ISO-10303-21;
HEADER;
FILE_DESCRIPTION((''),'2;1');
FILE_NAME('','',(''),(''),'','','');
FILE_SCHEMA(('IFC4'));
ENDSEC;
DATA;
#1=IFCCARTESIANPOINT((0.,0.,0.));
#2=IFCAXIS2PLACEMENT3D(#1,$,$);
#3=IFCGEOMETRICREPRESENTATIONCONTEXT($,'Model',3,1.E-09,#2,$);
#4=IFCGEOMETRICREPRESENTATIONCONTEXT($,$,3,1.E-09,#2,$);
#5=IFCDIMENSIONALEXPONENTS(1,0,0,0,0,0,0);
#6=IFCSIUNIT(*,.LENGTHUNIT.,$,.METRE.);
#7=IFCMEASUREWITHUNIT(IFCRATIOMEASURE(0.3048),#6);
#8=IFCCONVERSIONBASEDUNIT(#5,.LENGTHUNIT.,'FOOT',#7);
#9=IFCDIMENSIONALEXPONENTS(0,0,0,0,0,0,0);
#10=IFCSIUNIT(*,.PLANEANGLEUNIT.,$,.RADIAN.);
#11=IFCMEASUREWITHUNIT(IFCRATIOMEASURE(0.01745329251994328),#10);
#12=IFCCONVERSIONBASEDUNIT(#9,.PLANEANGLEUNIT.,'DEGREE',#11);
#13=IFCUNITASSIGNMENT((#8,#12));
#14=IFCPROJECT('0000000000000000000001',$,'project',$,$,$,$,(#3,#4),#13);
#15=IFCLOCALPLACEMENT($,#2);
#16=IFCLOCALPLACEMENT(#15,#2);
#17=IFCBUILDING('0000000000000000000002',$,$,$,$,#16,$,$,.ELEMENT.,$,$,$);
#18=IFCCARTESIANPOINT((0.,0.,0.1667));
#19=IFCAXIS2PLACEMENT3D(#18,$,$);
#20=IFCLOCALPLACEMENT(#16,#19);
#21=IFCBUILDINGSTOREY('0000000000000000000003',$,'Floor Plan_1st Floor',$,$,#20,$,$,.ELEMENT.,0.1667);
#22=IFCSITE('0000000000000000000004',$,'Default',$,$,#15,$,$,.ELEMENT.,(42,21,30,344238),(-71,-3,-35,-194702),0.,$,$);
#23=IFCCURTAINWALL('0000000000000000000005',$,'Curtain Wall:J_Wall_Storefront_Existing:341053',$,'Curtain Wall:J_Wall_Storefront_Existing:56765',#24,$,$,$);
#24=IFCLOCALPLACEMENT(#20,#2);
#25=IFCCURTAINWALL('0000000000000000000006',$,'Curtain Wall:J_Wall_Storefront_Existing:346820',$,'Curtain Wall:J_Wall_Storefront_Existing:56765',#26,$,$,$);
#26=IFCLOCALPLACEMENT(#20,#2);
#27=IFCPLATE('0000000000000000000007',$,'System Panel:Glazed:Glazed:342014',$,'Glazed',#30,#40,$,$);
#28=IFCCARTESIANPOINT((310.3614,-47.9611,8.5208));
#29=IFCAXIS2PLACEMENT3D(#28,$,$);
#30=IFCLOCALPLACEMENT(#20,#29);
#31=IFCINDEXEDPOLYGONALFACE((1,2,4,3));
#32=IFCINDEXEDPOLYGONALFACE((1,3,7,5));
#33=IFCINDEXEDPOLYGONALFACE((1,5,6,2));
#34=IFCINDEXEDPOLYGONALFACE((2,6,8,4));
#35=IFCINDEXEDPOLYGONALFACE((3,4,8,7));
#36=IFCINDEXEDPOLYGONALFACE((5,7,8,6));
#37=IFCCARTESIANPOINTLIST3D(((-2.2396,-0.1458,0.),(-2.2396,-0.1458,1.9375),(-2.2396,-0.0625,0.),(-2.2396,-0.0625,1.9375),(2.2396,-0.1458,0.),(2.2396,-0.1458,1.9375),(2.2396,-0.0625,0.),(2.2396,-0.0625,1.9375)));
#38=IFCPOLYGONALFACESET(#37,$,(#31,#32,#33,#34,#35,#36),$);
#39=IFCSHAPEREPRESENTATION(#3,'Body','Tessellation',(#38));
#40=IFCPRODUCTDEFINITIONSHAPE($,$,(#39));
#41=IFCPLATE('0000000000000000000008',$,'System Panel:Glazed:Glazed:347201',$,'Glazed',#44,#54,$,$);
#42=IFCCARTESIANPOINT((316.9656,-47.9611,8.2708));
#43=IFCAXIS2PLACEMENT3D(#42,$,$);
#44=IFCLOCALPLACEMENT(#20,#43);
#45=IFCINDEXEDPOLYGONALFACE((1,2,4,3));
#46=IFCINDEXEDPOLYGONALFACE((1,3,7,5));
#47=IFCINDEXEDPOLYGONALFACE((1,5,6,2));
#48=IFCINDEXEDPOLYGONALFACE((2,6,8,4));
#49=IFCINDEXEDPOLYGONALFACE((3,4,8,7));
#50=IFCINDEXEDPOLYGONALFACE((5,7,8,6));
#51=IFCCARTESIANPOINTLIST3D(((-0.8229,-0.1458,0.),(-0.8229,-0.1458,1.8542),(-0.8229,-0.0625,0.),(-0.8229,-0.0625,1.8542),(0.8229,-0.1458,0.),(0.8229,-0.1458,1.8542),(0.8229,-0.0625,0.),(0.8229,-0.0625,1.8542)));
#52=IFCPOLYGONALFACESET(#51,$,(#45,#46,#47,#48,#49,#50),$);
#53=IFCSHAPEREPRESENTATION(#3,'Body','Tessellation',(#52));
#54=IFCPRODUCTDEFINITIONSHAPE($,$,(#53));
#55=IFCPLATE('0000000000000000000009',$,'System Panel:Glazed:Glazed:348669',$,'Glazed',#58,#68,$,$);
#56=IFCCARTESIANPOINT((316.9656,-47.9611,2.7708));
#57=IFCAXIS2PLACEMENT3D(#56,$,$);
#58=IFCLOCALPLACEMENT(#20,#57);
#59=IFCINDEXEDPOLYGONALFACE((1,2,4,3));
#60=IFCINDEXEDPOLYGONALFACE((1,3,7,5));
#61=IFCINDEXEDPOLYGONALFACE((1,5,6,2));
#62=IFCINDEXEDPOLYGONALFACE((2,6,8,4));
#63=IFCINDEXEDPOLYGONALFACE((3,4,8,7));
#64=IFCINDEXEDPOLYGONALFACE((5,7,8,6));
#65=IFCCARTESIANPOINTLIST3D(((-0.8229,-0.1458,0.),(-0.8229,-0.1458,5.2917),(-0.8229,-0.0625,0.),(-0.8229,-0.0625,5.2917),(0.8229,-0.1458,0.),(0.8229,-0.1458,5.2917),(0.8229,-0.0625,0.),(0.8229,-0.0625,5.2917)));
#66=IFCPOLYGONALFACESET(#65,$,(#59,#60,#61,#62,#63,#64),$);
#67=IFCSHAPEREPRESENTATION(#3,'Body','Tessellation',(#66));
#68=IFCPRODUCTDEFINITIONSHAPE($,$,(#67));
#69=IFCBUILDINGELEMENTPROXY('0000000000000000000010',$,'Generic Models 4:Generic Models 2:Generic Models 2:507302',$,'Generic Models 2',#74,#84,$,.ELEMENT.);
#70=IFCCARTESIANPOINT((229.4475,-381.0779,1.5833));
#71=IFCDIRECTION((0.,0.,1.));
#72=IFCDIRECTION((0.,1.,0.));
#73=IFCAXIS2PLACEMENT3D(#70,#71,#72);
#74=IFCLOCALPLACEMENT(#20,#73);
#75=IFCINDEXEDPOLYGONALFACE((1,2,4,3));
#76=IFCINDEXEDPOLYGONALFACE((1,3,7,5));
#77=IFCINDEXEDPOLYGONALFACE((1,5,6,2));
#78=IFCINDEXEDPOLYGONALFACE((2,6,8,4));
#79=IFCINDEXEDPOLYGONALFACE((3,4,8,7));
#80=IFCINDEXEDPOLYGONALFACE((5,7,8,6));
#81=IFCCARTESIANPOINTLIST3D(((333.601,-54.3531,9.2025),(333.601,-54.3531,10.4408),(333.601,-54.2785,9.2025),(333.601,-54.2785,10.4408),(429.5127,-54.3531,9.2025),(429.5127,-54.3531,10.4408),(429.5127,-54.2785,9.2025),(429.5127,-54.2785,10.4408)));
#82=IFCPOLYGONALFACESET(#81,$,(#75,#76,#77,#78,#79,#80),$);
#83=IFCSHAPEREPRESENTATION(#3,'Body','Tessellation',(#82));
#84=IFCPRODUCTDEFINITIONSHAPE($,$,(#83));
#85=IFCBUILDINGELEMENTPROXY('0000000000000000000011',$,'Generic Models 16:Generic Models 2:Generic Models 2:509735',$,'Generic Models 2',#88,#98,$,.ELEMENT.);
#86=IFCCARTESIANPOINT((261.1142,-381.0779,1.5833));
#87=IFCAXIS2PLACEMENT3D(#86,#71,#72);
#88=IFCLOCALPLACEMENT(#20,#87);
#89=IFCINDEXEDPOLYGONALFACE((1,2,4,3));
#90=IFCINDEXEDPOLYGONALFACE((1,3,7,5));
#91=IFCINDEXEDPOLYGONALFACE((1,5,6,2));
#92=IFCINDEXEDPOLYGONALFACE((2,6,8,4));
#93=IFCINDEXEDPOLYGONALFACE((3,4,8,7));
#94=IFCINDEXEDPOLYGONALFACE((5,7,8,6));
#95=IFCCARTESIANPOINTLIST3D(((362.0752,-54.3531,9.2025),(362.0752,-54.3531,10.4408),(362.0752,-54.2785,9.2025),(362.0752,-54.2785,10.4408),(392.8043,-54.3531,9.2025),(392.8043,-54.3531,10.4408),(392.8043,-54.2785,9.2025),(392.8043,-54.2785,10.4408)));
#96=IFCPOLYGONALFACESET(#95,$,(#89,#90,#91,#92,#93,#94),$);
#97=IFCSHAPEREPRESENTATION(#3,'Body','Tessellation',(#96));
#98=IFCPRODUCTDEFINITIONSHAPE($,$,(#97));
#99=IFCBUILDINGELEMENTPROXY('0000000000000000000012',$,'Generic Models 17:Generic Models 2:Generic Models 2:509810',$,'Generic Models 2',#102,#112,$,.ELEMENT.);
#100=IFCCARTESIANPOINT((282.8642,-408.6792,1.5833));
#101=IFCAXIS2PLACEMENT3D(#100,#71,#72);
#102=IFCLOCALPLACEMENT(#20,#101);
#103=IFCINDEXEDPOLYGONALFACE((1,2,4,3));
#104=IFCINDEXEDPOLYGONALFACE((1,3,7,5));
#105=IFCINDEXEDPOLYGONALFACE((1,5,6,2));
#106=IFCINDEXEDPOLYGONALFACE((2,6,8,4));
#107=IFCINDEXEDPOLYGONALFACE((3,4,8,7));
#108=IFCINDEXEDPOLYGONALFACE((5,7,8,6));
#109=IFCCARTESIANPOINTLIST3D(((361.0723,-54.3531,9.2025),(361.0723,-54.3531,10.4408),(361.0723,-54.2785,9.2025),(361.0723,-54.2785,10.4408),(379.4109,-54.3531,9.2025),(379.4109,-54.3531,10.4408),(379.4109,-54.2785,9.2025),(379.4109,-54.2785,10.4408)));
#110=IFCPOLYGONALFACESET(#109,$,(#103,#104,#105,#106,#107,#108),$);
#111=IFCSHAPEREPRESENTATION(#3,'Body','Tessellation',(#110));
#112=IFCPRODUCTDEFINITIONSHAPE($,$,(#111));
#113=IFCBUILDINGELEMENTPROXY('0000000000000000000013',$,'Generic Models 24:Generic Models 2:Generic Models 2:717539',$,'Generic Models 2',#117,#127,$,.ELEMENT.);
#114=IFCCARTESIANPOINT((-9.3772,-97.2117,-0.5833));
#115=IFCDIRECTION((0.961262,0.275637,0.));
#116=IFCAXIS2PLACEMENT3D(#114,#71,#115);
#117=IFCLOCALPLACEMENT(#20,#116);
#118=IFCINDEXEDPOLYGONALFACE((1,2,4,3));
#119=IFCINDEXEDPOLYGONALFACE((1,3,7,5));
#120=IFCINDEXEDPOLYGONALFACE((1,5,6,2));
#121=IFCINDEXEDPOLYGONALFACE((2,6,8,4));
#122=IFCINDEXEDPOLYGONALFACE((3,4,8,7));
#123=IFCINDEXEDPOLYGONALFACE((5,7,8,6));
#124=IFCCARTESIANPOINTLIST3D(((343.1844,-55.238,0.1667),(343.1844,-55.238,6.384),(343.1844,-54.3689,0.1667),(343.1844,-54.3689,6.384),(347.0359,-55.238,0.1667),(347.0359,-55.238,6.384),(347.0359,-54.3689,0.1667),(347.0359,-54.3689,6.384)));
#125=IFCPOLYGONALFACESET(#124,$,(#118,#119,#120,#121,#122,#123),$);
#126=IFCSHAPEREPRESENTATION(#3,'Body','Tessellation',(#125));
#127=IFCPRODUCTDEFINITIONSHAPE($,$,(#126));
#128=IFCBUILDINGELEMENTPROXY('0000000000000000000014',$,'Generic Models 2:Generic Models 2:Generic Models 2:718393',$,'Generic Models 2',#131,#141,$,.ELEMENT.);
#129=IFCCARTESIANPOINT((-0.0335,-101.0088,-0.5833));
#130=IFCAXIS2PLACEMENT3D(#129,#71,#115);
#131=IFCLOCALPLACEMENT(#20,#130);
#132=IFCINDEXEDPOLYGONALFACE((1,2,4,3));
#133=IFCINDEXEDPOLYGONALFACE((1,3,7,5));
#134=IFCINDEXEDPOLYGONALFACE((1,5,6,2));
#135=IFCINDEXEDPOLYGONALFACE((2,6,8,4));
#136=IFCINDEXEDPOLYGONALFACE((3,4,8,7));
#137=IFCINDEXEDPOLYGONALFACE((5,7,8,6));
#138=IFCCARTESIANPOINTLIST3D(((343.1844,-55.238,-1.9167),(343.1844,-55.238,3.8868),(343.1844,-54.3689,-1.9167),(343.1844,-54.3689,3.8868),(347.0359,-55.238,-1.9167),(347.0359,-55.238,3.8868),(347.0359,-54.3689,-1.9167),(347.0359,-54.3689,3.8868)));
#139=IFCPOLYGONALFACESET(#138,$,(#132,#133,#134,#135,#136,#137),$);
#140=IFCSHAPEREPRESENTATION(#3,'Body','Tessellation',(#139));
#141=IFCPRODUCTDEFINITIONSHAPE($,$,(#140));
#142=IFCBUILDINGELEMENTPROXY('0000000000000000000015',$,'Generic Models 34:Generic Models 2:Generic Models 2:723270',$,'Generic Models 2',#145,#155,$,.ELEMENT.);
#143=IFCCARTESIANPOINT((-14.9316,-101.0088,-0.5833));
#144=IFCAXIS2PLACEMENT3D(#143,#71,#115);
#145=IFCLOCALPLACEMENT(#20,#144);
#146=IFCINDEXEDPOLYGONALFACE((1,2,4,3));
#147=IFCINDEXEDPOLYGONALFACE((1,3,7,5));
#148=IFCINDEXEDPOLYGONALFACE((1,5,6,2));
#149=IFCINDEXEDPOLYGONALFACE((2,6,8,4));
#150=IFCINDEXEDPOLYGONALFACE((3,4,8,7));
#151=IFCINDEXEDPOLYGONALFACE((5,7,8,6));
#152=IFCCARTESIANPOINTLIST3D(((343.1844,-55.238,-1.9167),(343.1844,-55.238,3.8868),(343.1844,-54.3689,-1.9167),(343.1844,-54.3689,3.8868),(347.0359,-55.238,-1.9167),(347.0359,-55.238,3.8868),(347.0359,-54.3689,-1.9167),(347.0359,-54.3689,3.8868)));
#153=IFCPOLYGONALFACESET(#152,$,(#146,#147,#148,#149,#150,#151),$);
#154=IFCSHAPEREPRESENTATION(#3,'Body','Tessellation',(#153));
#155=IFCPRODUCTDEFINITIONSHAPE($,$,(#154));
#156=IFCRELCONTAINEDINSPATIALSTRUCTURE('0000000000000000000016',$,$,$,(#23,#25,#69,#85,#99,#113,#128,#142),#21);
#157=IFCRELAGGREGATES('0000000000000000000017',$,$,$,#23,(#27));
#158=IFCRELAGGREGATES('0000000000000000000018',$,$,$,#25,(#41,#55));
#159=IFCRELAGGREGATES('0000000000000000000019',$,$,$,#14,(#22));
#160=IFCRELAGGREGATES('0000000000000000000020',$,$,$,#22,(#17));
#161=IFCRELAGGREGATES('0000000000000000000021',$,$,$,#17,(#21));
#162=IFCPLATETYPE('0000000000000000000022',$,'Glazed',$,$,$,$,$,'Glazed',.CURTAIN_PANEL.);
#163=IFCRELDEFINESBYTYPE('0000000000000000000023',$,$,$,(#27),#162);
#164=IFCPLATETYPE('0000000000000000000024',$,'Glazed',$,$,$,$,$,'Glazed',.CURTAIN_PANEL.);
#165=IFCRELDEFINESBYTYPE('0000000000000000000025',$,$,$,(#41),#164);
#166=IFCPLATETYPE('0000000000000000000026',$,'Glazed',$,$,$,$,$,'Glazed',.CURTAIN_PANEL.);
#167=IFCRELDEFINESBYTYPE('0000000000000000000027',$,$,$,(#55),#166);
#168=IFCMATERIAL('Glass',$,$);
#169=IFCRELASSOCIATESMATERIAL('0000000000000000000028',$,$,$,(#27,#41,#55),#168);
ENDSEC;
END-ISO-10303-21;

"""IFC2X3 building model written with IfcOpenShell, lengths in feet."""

from ifc_helpers import new_model, entity, si_unit, converted_unit, frame, origin, origin_2d_with_axis, place, context, project, spatial, rectangle, extrude, source, transform, mapped, material, type_object, type_shapes, element, aggregate, save


model = new_model("IFC2X3")

# Units and contexts
model_context = context("Model", 3, precision=1e-09, world=origin())
context_of_model = context(None, 3, precision=1e-09, world=origin())
ifc_project = project(units=[converted_unit("LENGTHUNIT", "FOOT", entity("IfcRatioMeasure", 0.3048), si_unit("LENGTHUNIT", "METRE"), dimensions=[1, 0, 0, 0, 0, 0, 0]), converted_unit("PLANEANGLEUNIT", "DEGREE", entity("IfcRatioMeasure", 0.01745329251994328), si_unit("PLANEANGLEUNIT", "RADIAN"), dimensions=[0, 0, 0, 0, 0, 0, 0])], contexts=[model_context, context_of_model])

# Site, building, storey
site_placement = place(None, origin())
site = spatial("IfcSite", under=ifc_project, at=site_placement, Name="Default", CompositionType="ELEMENT", RefLatitude=(42, 21, 30, 344238), RefLongitude=(-71, -3, -35, -194702), RefElevation=0.0)
building_placement = place(site_placement, origin())
building = spatial("IfcBuilding", under=site, at=building_placement, CompositionType="ELEMENT")
storey_placement = place(building_placement, frame((0.0, 0.0, 0.1667)))
storey = spatial("IfcBuildingStorey", under=building, at=storey_placement, Name="Floor Plan_1st Floor", CompositionType="ELEMENT", Elevation=0.1667)

# Curtain walls
curtain_wall_1_placement = place(storey_placement, origin())
curtain_wall_1 = element("IfcCurtainWall", 1, at=curtain_wall_1_placement, inside=storey, Name="Curtain Wall:J_Wall_Storefront_Existing:341053", ObjectType="Curtain Wall:J_Wall_Storefront_Existing:56765")
curtain_wall_2_placement = place(storey_placement, origin())
curtain_wall_2 = element("IfcCurtainWall", 2, at=curtain_wall_2_placement, inside=storey, Name="Curtain Wall:J_Wall_Storefront_Existing:346820", ObjectType="Curtain Wall:J_Wall_Storefront_Existing:56765")

# Plates
ifc_material_1 = material(Name="Glass")
plate_type_1 = type_object("IfcPlateType", Name="Glazed", ElementType="Glazed", PredefinedType="CURTAIN_PANEL")
shared_shape_1 = source(origin(), model_context, "Body", "SweptSolid", [
    extrude(rectangle(XDim=0.0833, YDim=4.4792, at=origin_2d_with_axis()), frame((0.0, -0.1042, 0.0), z_axis=(0.0, 0.0, 1.0), x_axis=(0.0, 1.0, 0.0)), (0.0, 0.0, 1.0), 1.9375),
])
type_shapes(plate_type_1, [shared_shape_1])
plate_1_placement = place(storey_placement, frame((310.3614, -47.9611, 8.5208)))
plate_1 = element("IfcPlate", 3, at=plate_1_placement, type_object=plate_type_1, material=ifc_material_1, Name="System Panel:Glazed:Glazed:342014", ObjectType="Glazed", context=model_context, shape_type="MappedRepresentation", body=[
    mapped(shared_shape_1, transform((0.0, 0.0, 0.0), scale=1.0)),
])
aggregate(curtain_wall_1, [plate_1])
plate_type_2 = type_object("IfcPlateType", Name="Glazed", ElementType="Glazed", PredefinedType="CURTAIN_PANEL")
shared_shape_2 = source(origin(), model_context, "Body", "SweptSolid", [
    extrude(rectangle(XDim=0.0833, YDim=1.6458, at=origin_2d_with_axis()), frame((0.0, -0.1042, 0.0), z_axis=(0.0, 0.0, 1.0), x_axis=(0.0, 1.0, 0.0)), (0.0, 0.0, 1.0), 1.8542),
])
type_shapes(plate_type_2, [shared_shape_2])
plate_2_placement = place(storey_placement, frame((316.9656, -47.9611, 8.2708)))
plate_2 = element("IfcPlate", 4, at=plate_2_placement, type_object=plate_type_2, material=ifc_material_1, Name="System Panel:Glazed:Glazed:347201", ObjectType="Glazed", context=model_context, shape_type="MappedRepresentation", body=[
    mapped(shared_shape_2, transform((0.0, 0.0, 0.0), scale=1.0)),
])
plate_type_3 = type_object("IfcPlateType", Name="Glazed", ElementType="Glazed", PredefinedType="CURTAIN_PANEL")
shared_shape_3 = source(origin(), model_context, "Body", "SweptSolid", [
    extrude(rectangle(XDim=0.0833, YDim=1.6458, at=origin_2d_with_axis()), frame((0.0, -0.1042, 0.0), z_axis=(0.0, 0.0, 1.0), x_axis=(0.0, 1.0, 0.0)), (0.0, 0.0, 1.0), 5.2917),
])
type_shapes(plate_type_3, [shared_shape_3])
plate_3_placement = place(storey_placement, frame((316.9656, -47.9611, 2.7708)))
plate_3 = element("IfcPlate", 5, at=plate_3_placement, type_object=plate_type_3, material=ifc_material_1, Name="System Panel:Glazed:Glazed:348669", ObjectType="Glazed", context=model_context, shape_type="MappedRepresentation", body=[
    mapped(shared_shape_3, transform((0.0, 0.0, 0.0), scale=1.0)),
])
aggregate(curtain_wall_2, [plate_2, plate_3])

# Building element proxies
shared_shape_4 = source(origin(), model_context, "Body", "SweptSolid", [
    extrude(rectangle(XDim=95.9117, YDim=0.0746, at=origin_2d_with_axis()), frame((381.5568, -54.3158, 9.2025)), (0.0, 0.0, 1.0), 1.2382),
])
proxy_1_placement = place(storey_placement, frame((229.4475, -381.0779, 1.5833), z_axis=(0.0, 0.0, 1.0), x_axis=(0.0, 1.0, 0.0)))
element("IfcBuildingElementProxy", 6, at=proxy_1_placement, inside=storey, Name="Generic Models 4:Generic Models 2:Generic Models 2:507302", ObjectType="Generic Models 2", CompositionType="ELEMENT", context=model_context, shape_type="MappedRepresentation", body=[
    mapped(shared_shape_4, transform((0.0, 0.0, 0.0), scale=1.0)),
])
shared_shape_5 = source(origin(), model_context, "Body", "SweptSolid", [
    extrude(rectangle(XDim=30.7291, YDim=0.0746, at=origin_2d_with_axis()), frame((377.4397, -54.3158, 9.2025)), (0.0, 0.0, 1.0), 1.2382),
])
proxy_2_placement = place(storey_placement, frame((261.1142, -381.0779, 1.5833), z_axis=(0.0, 0.0, 1.0), x_axis=(0.0, 1.0, 0.0)))
element("IfcBuildingElementProxy", 7, at=proxy_2_placement, inside=storey, Name="Generic Models 16:Generic Models 2:Generic Models 2:509735", ObjectType="Generic Models 2", CompositionType="ELEMENT", context=model_context, shape_type="MappedRepresentation", body=[
    mapped(shared_shape_5, transform((0.0, 0.0, 0.0), scale=1.0)),
])
shared_shape_6 = source(origin(), model_context, "Body", "SweptSolid", [
    extrude(rectangle(XDim=18.3385, YDim=0.0746, at=origin_2d_with_axis()), frame((370.2416, -54.3158, 9.2025)), (0.0, 0.0, 1.0), 1.2382),
])
proxy_3_placement = place(storey_placement, frame((282.8642, -408.6792, 1.5833), z_axis=(0.0, 0.0, 1.0), x_axis=(0.0, 1.0, 0.0)))
element("IfcBuildingElementProxy", 8, at=proxy_3_placement, inside=storey, Name="Generic Models 17:Generic Models 2:Generic Models 2:509810", ObjectType="Generic Models 2", CompositionType="ELEMENT", context=model_context, shape_type="MappedRepresentation", body=[
    mapped(shared_shape_6, transform((0.0, 0.0, 0.0), scale=1.0)),
])
shared_shape_7 = source(origin(), model_context, "Body", "SweptSolid", [
    extrude(rectangle(XDim=3.8516, YDim=0.8691, at=origin_2d_with_axis()), frame((345.1101, -54.8035, 0.1667)), (0.0, 0.0, 1.0), 6.2173),
])
proxy_4_placement = place(storey_placement, frame((-9.3772, -97.2117, -0.5833), z_axis=(0.0, 0.0, 1.0), x_axis=(0.961262, 0.275637, 0.0)))
element("IfcBuildingElementProxy", 9, at=proxy_4_placement, inside=storey, Name="Generic Models 24:Generic Models 2:Generic Models 2:717539", ObjectType="Generic Models 2", CompositionType="ELEMENT", context=model_context, shape_type="MappedRepresentation", body=[
    mapped(shared_shape_7, transform((0.0, 0.0, 0.0), scale=1.0)),
])
shared_shape_8 = source(origin(), model_context, "Body", "SweptSolid", [
    extrude(rectangle(XDim=3.8516, YDim=0.8691, at=origin_2d_with_axis()), frame((345.1101, -54.8035, -1.9167)), (0.0, 0.0, 1.0), 5.8035),
])
proxy_5_placement = place(storey_placement, frame((-0.0335, -101.0088, -0.5833), z_axis=(0.0, 0.0, 1.0), x_axis=(0.961262, 0.275637, 0.0)))
element("IfcBuildingElementProxy", 10, at=proxy_5_placement, inside=storey, Name="Generic Models 2:Generic Models 2:Generic Models 2:718393", ObjectType="Generic Models 2", CompositionType="ELEMENT", context=model_context, shape_type="MappedRepresentation", body=[
    mapped(shared_shape_8, transform((0.0, 0.0, 0.0), scale=1.0)),
])
shared_shape_9 = source(origin(), model_context, "Body", "SweptSolid", [
    extrude(rectangle(XDim=3.8516, YDim=0.8691, at=origin_2d_with_axis()), frame((345.1101, -54.8035, -1.9167)), (0.0, 0.0, 1.0), 5.8035),
])
proxy_6_placement = place(storey_placement, frame((-14.9316, -101.0088, -0.5833), z_axis=(0.0, 0.0, 1.0), x_axis=(0.961262, 0.275637, 0.0)))
element("IfcBuildingElementProxy", 11, at=proxy_6_placement, inside=storey, Name="Generic Models 34:Generic Models 2:Generic Models 2:723270", ObjectType="Generic Models 2", CompositionType="ELEMENT", context=model_context, shape_type="MappedRepresentation", body=[
    mapped(shared_shape_9, transform((0.0, 0.0, 0.0), scale=1.0)),
])

save(model, "model.ifc")
